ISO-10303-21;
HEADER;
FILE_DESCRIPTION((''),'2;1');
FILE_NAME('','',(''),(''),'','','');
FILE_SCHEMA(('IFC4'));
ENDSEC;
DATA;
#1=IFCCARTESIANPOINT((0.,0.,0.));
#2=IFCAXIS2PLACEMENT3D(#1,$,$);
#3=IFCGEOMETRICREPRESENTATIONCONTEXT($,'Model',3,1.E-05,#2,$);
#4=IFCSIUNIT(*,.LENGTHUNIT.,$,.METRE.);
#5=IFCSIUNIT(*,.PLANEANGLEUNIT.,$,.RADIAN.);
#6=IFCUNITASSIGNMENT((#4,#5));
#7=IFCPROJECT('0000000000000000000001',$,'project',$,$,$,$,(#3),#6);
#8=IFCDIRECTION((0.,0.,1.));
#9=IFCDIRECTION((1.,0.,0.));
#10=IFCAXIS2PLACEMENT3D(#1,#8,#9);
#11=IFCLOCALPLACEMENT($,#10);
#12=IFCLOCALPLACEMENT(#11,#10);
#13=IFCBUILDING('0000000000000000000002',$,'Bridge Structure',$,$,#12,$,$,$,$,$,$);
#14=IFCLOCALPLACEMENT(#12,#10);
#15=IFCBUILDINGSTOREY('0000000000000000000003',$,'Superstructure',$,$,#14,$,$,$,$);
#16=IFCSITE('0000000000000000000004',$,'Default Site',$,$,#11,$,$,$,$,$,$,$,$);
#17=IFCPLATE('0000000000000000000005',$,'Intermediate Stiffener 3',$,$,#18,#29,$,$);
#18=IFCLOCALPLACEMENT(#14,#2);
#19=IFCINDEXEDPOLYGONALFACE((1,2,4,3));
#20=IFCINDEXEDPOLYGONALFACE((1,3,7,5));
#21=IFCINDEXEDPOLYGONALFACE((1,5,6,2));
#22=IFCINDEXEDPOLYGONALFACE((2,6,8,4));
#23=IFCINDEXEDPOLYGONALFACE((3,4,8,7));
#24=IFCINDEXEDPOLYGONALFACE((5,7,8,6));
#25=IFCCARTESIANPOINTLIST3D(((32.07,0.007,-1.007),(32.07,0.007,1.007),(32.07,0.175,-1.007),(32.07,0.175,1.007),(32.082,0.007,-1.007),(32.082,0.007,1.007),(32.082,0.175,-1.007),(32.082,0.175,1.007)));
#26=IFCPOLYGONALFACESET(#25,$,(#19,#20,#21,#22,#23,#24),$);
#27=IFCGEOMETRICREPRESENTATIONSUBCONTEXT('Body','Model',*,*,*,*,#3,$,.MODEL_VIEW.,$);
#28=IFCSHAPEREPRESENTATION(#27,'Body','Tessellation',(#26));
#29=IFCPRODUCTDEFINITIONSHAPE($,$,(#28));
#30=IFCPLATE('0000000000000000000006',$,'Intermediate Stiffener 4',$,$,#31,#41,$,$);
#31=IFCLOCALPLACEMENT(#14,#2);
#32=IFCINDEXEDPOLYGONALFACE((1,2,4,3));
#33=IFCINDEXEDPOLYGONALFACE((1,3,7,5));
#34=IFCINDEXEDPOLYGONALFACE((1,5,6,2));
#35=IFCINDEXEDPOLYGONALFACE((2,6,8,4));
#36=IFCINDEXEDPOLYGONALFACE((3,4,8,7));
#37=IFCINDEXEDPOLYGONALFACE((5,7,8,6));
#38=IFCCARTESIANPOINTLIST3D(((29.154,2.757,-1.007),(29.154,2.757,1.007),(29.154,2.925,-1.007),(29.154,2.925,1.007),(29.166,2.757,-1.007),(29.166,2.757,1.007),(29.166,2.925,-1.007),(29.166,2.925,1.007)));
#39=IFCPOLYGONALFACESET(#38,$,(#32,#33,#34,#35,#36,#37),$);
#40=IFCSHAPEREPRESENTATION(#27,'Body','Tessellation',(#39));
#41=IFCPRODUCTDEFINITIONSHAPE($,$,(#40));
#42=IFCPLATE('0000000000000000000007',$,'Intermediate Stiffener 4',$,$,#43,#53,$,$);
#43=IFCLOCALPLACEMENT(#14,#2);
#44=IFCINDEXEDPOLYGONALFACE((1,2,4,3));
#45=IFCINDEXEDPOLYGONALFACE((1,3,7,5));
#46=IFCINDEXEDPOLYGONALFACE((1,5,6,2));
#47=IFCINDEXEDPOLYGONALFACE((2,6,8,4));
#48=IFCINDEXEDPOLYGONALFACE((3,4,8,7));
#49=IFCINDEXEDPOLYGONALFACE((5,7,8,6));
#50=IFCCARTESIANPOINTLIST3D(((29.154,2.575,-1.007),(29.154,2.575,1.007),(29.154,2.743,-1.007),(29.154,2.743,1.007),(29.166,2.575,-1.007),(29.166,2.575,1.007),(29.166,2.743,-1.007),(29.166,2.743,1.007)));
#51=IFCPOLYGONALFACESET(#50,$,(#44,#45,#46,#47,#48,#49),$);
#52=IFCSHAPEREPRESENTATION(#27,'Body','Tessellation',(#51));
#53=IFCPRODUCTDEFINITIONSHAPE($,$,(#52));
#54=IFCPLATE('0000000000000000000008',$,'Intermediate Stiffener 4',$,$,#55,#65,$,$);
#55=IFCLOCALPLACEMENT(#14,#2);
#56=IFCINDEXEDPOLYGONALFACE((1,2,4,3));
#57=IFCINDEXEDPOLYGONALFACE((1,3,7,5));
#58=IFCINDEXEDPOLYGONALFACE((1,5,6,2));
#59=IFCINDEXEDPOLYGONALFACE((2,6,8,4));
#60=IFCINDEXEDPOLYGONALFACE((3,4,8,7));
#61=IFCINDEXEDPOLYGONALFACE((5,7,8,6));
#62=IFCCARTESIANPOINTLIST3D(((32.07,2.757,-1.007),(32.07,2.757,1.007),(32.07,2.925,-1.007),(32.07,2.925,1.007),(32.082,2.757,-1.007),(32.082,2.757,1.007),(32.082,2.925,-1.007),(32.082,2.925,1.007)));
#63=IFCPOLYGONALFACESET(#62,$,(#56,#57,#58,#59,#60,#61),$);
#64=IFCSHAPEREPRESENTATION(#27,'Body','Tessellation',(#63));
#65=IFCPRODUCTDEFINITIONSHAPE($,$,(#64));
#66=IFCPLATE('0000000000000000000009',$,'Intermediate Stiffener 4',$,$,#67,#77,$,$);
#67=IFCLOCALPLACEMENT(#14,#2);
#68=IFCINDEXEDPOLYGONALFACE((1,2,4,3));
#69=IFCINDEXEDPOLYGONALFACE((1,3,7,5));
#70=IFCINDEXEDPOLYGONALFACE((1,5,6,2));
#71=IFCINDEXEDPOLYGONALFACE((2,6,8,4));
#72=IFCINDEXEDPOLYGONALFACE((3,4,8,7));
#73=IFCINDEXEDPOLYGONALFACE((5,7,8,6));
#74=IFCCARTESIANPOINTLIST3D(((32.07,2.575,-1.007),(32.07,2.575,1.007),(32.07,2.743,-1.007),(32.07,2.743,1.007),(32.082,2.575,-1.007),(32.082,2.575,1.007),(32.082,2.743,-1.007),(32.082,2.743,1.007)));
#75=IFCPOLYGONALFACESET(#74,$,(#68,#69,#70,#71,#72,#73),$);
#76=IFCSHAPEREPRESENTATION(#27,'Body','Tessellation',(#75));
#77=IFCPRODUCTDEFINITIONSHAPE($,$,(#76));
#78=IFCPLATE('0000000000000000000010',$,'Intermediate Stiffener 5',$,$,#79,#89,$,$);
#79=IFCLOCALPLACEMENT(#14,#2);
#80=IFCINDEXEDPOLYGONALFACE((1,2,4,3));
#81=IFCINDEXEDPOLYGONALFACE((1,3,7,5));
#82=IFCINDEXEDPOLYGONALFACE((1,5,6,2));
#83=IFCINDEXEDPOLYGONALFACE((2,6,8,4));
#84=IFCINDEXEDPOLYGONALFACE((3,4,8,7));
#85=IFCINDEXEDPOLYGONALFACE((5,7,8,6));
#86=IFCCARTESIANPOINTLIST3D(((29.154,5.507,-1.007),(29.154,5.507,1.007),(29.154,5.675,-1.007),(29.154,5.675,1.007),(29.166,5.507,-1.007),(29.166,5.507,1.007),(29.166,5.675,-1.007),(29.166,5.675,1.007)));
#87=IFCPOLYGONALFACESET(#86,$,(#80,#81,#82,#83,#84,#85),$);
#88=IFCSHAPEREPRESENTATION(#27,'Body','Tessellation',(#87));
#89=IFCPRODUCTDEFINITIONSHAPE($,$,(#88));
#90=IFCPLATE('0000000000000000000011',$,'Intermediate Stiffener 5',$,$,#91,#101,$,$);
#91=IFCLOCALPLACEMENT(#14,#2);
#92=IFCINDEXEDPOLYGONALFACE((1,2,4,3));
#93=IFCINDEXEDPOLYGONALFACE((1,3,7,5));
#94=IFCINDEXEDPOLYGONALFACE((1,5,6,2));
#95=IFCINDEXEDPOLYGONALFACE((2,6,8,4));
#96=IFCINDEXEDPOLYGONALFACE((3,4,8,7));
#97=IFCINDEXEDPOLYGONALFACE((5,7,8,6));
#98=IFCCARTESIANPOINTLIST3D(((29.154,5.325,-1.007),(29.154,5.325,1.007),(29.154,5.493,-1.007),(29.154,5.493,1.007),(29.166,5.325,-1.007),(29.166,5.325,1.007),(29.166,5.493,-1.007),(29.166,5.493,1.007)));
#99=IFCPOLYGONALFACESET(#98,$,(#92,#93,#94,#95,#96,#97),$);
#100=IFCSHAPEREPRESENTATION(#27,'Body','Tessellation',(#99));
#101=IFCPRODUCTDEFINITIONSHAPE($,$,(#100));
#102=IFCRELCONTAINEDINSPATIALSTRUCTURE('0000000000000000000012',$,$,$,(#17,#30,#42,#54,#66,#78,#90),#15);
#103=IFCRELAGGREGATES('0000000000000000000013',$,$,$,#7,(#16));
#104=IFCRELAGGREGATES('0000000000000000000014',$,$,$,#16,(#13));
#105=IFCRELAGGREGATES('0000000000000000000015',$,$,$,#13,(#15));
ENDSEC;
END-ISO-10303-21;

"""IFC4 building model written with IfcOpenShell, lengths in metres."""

from ifc_helpers import new_model, si_unit, frame, origin, origin_with_axes, origin_2d_with_axis, place, context, subcontext, project, spatial, rectangle, extrude, element, save


model = new_model("IFC4")

# Units and contexts
model_context = context("Model", 3, precision=1e-05, world=origin())
body_context = subcontext(model_context, "Body", "Model", "MODEL_VIEW")
ifc_project = project(units=[si_unit("LENGTHUNIT", "METRE"), si_unit("PLANEANGLEUNIT", "RADIAN")], contexts=[model_context])

# Site, building, storey
site_placement = place(None, origin_with_axes())
site = spatial("IfcSite", under=ifc_project, at=site_placement, Name="Default Site")
building_placement = place(site_placement, origin_with_axes())
building = spatial("IfcBuilding", under=site, at=building_placement, Name="Bridge Structure")
storey_placement = place(building_placement, origin_with_axes())
storey = spatial("IfcBuildingStorey", under=building, at=storey_placement, Name="Superstructure")

# Plates
for number, where, z_axis, x_axis, name in (
    (1, (32.076, 0.091, -1.007), (0.0, 0.0, 1.0), (1.0, 0.0, 0.0), "Intermediate Stiffener 3"),
    (2, (29.16, 2.841, -1.007), (0.0, 0.0, 1.0), (1.0, 0.0, 0.0), "Intermediate Stiffener 4"),
    (3, (29.16, 2.659, -1.007), (0.0, 0.0, 1.0), (1.0, 0.0, 0.0), "Intermediate Stiffener 4"),
    (4, (32.076, 2.841, -1.007), (0.0, 0.0, 1.0), (1.0, 0.0, 0.0), "Intermediate Stiffener 4"),
    (5, (32.076, 2.659, -1.007), (0.0, 0.0, 1.0), (1.0, 0.0, 0.0), "Intermediate Stiffener 4"),
    (6, (29.16, 5.591, -1.007), (0.0, 0.0, 1.0), (1.0, 0.0, 0.0), "Intermediate Stiffener 5"),
    (7, (29.16, 5.409, -1.007), (0.0, 0.0, 1.0), (1.0, 0.0, 0.0), "Intermediate Stiffener 5"),
):
    element("IfcPlate", number, at=place(storey_placement, frame(where, z_axis=z_axis, x_axis=x_axis)), inside=storey, Name=name, context=body_context, shape_type="SweptSolid", body=[
        extrude(rectangle(XDim=0.012, YDim=0.168, at=origin_2d_with_axis()), origin_with_axes(), (0.0, 0.0, 1.0), 2.014),
    ])

save(model, "model.ifc")
